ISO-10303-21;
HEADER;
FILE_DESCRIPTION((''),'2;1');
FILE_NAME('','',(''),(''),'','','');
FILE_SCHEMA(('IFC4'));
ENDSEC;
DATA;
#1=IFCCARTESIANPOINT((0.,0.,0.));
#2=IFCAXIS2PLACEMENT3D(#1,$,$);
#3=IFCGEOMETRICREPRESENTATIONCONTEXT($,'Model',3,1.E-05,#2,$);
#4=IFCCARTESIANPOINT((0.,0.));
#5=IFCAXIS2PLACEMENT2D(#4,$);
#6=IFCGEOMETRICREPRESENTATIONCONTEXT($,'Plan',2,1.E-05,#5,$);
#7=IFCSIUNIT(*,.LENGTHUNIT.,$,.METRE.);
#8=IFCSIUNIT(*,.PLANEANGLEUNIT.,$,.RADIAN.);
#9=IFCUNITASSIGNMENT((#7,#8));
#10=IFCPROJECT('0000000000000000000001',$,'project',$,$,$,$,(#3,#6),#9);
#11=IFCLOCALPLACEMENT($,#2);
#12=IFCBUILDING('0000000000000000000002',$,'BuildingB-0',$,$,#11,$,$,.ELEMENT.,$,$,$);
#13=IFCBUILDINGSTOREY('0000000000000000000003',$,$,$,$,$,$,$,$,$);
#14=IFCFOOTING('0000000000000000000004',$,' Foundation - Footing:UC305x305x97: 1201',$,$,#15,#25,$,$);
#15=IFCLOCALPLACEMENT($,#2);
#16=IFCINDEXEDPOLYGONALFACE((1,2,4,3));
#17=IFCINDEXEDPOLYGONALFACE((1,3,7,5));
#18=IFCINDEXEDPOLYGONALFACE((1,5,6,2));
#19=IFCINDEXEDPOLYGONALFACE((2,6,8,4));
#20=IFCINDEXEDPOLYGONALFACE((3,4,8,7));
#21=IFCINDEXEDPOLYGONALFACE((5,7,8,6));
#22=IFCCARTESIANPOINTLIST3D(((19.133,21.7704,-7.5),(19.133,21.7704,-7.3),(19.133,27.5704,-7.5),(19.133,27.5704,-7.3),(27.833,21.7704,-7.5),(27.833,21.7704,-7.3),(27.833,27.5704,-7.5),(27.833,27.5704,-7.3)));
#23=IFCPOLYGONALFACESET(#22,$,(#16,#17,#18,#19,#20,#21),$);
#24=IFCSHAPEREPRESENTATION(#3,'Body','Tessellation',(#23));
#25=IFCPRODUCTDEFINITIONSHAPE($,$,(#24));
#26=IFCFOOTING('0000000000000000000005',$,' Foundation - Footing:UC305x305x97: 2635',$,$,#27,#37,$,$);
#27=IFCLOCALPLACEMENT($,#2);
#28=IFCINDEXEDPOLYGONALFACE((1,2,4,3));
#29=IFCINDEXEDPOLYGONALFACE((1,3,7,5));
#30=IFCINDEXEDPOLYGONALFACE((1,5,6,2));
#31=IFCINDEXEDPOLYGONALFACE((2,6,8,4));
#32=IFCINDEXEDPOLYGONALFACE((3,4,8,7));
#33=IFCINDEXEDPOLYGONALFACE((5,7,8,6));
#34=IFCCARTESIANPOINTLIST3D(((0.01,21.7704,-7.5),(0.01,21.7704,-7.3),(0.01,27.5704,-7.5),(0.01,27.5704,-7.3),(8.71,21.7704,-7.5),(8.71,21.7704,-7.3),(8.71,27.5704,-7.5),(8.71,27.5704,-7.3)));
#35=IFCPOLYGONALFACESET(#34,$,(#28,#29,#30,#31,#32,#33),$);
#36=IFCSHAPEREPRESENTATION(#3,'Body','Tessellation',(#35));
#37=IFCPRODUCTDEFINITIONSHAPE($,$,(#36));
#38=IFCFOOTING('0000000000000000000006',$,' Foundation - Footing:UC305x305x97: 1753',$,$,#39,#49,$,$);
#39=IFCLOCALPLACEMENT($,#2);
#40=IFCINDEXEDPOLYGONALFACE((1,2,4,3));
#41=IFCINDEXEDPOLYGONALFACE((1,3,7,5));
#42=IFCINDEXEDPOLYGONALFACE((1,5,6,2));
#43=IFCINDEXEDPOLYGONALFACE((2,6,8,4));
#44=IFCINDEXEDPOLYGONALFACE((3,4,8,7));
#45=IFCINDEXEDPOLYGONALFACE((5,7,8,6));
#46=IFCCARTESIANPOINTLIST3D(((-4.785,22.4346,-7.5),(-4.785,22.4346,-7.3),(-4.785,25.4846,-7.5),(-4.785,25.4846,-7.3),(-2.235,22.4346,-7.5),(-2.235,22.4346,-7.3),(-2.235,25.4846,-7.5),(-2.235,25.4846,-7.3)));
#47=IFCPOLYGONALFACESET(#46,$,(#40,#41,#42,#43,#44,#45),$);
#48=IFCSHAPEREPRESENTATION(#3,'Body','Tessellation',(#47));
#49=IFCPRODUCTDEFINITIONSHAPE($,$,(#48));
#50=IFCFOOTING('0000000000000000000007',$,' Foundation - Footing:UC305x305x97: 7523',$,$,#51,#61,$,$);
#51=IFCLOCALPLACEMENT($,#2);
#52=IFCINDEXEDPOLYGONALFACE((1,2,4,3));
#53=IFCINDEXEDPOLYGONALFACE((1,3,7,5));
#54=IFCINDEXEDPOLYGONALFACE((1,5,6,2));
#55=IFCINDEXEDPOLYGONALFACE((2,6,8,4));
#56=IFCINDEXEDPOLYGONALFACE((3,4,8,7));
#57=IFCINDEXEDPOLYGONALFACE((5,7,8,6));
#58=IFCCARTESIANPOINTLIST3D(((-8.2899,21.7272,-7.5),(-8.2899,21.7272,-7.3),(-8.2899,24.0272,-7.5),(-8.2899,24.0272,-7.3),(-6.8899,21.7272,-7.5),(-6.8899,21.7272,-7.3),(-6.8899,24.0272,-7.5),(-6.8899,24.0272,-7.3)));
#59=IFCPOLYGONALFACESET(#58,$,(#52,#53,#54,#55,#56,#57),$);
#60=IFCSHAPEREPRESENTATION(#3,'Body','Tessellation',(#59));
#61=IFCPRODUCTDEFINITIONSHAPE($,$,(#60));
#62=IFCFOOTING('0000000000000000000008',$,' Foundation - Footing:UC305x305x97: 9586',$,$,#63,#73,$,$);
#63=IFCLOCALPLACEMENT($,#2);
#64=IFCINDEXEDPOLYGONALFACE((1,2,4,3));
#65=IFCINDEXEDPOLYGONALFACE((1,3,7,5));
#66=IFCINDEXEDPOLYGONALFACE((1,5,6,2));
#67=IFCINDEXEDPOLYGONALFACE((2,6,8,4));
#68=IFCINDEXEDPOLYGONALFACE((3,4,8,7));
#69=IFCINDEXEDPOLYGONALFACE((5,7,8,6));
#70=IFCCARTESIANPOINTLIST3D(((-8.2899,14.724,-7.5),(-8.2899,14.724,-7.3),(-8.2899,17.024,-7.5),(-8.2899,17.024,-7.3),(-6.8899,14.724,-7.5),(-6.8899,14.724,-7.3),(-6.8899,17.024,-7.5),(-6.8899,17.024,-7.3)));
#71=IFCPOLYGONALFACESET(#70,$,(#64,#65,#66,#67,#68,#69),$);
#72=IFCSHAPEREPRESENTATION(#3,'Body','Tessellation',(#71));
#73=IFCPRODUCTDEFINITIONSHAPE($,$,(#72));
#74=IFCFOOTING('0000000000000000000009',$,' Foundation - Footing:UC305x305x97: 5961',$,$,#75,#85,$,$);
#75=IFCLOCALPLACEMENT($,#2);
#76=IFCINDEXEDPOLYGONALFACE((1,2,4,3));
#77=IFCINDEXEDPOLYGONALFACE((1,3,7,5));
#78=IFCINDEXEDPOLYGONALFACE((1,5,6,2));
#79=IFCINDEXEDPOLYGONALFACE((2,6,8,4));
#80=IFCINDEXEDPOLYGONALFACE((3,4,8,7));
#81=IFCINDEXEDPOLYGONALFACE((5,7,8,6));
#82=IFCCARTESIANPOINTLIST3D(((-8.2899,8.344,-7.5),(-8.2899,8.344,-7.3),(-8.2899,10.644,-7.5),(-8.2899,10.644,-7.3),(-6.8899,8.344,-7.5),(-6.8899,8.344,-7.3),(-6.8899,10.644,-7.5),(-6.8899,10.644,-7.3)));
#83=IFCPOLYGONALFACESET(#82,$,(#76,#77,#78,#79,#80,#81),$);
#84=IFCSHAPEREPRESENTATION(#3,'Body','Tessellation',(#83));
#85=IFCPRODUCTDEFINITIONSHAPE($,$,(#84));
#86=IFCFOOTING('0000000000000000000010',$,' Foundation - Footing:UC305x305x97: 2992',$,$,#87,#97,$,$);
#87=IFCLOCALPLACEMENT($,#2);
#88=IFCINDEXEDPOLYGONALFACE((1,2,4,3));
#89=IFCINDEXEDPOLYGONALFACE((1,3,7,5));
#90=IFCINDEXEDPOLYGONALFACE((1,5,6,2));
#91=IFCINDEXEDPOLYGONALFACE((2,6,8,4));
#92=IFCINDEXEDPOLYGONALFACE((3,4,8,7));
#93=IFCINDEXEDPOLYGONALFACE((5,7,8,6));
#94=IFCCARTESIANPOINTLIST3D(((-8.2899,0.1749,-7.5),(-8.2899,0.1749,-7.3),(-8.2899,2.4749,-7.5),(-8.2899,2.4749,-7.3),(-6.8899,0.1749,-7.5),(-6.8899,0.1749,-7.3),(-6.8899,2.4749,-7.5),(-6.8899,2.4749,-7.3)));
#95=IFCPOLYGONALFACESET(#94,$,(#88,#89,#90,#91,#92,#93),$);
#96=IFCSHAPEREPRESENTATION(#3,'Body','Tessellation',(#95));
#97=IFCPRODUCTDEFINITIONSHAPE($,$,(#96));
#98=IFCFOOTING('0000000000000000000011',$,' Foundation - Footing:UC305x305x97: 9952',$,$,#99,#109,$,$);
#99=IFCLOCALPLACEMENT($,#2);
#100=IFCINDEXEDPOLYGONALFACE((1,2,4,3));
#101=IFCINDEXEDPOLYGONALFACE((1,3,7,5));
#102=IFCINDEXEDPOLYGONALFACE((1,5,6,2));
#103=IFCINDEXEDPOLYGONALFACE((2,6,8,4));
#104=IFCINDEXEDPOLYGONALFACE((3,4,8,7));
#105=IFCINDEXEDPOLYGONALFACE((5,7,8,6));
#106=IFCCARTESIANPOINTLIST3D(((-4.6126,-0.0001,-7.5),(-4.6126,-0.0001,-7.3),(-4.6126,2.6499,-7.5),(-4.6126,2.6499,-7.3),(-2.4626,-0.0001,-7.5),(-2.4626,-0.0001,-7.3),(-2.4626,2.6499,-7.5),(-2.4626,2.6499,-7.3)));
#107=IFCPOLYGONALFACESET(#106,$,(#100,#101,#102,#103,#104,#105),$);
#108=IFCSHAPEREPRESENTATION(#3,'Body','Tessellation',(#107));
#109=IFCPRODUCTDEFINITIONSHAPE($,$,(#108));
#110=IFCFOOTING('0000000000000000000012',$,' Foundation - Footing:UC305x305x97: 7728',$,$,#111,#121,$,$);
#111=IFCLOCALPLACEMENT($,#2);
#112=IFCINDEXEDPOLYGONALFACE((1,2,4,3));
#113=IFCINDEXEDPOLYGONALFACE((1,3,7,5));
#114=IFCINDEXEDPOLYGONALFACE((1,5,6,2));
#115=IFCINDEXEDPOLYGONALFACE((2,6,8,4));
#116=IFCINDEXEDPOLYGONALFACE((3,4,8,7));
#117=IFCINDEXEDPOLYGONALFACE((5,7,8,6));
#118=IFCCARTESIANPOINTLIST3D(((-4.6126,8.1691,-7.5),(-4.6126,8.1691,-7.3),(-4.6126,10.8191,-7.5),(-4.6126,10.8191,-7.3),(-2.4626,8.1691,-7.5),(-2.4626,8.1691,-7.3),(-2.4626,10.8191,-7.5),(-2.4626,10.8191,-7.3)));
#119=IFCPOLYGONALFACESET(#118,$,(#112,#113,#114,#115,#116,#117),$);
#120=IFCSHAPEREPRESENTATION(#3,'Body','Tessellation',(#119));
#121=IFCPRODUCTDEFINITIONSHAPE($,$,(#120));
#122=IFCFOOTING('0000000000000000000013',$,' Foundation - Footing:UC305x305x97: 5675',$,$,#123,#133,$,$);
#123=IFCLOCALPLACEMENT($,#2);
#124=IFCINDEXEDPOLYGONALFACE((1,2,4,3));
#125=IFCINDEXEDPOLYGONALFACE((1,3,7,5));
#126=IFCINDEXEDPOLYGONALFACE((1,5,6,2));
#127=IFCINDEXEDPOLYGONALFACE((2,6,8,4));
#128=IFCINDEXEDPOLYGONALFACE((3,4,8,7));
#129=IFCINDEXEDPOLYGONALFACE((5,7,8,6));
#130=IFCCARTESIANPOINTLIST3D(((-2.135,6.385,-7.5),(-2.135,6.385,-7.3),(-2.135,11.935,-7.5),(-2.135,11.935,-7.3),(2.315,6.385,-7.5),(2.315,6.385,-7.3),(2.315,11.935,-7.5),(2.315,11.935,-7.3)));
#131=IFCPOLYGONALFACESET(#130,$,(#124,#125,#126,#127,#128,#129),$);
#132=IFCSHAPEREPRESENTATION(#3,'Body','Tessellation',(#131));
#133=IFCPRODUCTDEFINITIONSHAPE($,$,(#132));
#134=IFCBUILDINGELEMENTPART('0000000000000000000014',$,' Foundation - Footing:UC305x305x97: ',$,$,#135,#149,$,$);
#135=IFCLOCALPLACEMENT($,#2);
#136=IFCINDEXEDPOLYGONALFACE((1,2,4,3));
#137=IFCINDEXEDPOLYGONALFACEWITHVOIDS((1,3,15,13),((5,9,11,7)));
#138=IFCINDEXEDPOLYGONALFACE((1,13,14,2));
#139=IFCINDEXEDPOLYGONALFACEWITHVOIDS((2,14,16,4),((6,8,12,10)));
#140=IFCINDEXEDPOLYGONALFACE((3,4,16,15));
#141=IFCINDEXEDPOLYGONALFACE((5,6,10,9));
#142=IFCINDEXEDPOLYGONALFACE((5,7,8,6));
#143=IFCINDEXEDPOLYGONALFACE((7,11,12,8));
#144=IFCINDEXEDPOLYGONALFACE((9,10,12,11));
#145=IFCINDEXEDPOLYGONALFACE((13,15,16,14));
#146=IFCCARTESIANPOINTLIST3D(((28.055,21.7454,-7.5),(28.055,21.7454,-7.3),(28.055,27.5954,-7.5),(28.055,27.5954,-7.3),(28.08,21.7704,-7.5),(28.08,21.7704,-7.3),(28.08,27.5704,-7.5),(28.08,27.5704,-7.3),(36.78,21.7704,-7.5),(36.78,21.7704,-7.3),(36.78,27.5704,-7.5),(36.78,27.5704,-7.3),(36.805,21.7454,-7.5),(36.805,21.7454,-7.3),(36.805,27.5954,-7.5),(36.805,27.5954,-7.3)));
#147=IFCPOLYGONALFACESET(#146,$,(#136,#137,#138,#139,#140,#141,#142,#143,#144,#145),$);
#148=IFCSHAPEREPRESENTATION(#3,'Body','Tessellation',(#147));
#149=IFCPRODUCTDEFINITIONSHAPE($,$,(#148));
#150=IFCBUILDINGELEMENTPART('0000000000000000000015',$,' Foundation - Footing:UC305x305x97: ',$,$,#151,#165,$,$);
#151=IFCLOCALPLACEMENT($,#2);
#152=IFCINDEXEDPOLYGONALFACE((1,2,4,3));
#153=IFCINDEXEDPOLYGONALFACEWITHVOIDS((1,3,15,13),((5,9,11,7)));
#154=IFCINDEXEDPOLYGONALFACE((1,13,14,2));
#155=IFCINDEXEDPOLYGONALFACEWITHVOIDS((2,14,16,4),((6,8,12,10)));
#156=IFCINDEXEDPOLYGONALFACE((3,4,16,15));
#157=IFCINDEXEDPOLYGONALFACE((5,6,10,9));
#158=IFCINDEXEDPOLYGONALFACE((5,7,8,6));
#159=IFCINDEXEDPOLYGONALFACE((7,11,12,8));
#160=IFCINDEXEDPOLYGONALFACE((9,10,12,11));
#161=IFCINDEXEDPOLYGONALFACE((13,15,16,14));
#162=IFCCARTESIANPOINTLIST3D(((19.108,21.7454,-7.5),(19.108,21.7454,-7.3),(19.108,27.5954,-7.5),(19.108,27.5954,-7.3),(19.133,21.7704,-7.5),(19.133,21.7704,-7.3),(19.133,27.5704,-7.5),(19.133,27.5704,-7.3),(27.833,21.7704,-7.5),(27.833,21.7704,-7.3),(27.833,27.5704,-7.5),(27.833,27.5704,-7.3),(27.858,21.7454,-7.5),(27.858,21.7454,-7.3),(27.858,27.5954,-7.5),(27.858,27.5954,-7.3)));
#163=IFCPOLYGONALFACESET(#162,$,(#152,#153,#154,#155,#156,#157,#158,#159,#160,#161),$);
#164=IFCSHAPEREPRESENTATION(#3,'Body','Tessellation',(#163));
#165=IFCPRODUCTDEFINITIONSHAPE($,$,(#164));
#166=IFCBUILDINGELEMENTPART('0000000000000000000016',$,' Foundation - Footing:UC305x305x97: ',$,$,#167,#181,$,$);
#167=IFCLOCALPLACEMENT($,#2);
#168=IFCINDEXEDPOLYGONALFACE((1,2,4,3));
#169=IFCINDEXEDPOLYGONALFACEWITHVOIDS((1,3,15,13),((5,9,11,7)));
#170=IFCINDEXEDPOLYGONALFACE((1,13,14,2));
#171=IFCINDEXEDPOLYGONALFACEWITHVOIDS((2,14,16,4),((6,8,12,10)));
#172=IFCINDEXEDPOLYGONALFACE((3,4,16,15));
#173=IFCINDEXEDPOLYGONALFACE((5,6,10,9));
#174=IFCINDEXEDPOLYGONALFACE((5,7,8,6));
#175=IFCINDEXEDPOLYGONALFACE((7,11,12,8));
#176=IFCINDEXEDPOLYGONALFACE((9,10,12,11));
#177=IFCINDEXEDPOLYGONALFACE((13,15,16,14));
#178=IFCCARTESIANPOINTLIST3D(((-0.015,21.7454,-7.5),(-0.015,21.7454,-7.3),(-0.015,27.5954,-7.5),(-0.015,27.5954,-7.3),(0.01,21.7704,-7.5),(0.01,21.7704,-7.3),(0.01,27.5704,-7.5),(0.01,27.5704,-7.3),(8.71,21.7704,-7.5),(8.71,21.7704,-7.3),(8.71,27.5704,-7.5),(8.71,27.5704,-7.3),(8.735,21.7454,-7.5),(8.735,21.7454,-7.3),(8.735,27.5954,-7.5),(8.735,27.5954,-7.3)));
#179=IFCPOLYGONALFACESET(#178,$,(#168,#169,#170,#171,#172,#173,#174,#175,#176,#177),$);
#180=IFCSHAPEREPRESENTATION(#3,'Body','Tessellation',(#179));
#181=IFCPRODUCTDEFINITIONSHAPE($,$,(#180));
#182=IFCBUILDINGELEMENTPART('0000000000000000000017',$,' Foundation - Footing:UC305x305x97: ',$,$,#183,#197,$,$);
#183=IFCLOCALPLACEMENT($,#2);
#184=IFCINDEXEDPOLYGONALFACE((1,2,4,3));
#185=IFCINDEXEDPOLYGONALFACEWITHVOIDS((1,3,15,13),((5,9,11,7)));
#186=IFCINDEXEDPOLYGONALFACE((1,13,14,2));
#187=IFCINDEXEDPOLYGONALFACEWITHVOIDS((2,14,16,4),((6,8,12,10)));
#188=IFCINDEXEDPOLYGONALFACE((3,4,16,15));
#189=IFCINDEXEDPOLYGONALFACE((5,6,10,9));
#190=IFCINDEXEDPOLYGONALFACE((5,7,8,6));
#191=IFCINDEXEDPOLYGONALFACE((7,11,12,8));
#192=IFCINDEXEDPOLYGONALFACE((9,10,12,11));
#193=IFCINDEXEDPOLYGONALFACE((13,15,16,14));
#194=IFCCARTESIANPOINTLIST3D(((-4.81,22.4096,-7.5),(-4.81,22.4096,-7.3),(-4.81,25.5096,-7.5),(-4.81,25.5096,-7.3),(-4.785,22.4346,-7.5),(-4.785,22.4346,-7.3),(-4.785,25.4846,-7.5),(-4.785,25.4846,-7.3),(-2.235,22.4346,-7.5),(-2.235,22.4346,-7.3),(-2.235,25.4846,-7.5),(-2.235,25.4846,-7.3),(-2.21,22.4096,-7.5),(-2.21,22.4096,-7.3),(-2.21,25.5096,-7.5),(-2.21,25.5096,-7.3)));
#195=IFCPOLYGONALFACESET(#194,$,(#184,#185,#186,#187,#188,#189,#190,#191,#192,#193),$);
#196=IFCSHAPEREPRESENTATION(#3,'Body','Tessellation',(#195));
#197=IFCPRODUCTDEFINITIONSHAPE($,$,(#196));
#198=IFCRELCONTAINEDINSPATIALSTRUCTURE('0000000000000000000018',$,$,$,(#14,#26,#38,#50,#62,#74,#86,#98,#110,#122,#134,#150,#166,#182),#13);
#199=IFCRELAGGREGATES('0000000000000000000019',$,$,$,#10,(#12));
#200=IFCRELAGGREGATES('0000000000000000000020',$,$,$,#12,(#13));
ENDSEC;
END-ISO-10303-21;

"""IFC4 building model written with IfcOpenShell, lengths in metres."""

from ifc_helpers import new_model, si_unit, origin, origin_2d, place, context, project, spatial, polyline, outline, extrude, element, save


model = new_model("IFC4")

# Units and contexts
model_context = context("Model", 3, precision=1e-05, world=origin())
plan_context = context("Plan", 2, precision=1e-05, world=origin_2d())
ifc_project = project(units=[si_unit("LENGTHUNIT", "METRE"), si_unit("PLANEANGLEUNIT", "RADIAN")], contexts=[model_context, plan_context])

# Building, storey
building_placement = place(None, origin())
building = spatial("IfcBuilding", under=ifc_project, at=building_placement, Name="BuildingB-0", CompositionType="ELEMENT")
storey = spatial("IfcBuildingStorey", under=building)

# Footings
element("IfcFooting", 1, inside=storey, Name=" Foundation - Footing:UC305x305x97: 1201", context=model_context, shape_type="SweptSolid", body=[
    extrude(outline(polyline([(27.833, 27.5704, -7.5), (19.133, 27.5704, -7.5), (19.133, 21.7704, -7.5), (27.833, 21.7704, -7.5), (27.833, 27.5704, -7.5)])), None, (0.0, 0.0, 1.0), 0.2),
])
element("IfcFooting", 2, inside=storey, Name=" Foundation - Footing:UC305x305x97: 2635", context=model_context, shape_type="SweptSolid", body=[
    extrude(outline(polyline([(8.71, 27.5704, -7.5), (0.01, 27.5704, -7.5), (0.01, 21.7704, -7.5), (8.71, 21.7704, -7.5), (8.71, 27.5704, -7.5)])), None, (0.0, 0.0, 1.0), 0.2),
])
element("IfcFooting", 3, inside=storey, Name=" Foundation - Footing:UC305x305x97: 1753", context=model_context, shape_type="SweptSolid", body=[
    extrude(outline(polyline([(-2.235, 25.4846, -7.5), (-4.785, 25.4846, -7.5), (-4.785, 22.4346, -7.5), (-2.235, 22.4346, -7.5), (-2.235, 25.4846, -7.5)])), None, (0.0, 0.0, 1.0), 0.2),
])
element("IfcFooting", 4, inside=storey, Name=" Foundation - Footing:UC305x305x97: 7523", context=model_context, shape_type="SweptSolid", body=[
    extrude(outline(polyline([(-6.8899, 24.0272, -7.5), (-8.2899, 24.0272, -7.5), (-8.2899, 21.7272, -7.5), (-6.8899, 21.7272, -7.5), (-6.8899, 24.0272, -7.5)])), None, (0.0, 0.0, 1.0), 0.2),
])
element("IfcFooting", 5, inside=storey, Name=" Foundation - Footing:UC305x305x97: 9586", context=model_context, shape_type="SweptSolid", body=[
    extrude(outline(polyline([(-8.2899, 14.724, -7.5), (-6.8899, 14.724, -7.5), (-6.8899, 17.024, -7.5), (-8.2899, 17.024, -7.5), (-8.2899, 14.724, -7.5)])), None, (0.0, 0.0, 1.0), 0.2),
])
element("IfcFooting", 6, inside=storey, Name=" Foundation - Footing:UC305x305x97: 5961", context=model_context, shape_type="SweptSolid", body=[
    extrude(outline(polyline([(-8.2899, 8.344, -7.5), (-6.8899, 8.344, -7.5), (-6.8899, 10.644, -7.5), (-8.2899, 10.644, -7.5), (-8.2899, 8.344, -7.5)])), None, (0.0, 0.0, 1.0), 0.2),
])
element("IfcFooting", 7, inside=storey, Name=" Foundation - Footing:UC305x305x97: 2992", context=model_context, shape_type="SweptSolid", body=[
    extrude(outline(polyline([(-8.2899, 0.1749, -7.5), (-6.8899, 0.1749, -7.5), (-6.8899, 2.4749, -7.5), (-8.2899, 2.4749, -7.5), (-8.2899, 0.1749, -7.5)])), None, (0.0, 0.0, 1.0), 0.2),
])
element("IfcFooting", 8, inside=storey, Name=" Foundation - Footing:UC305x305x97: 9952", context=model_context, shape_type="SweptSolid", body=[
    extrude(outline(polyline([(-4.6126, -0.0001, -7.5), (-2.4626, -0.0001, -7.5), (-2.4626, 2.6499, -7.5), (-4.6126, 2.6499, -7.5), (-4.6126, -0.0001, -7.5)])), None, (0.0, 0.0, 1.0), 0.2),
])
element("IfcFooting", 9, inside=storey, Name=" Foundation - Footing:UC305x305x97: 7728", context=model_context, shape_type="SweptSolid", body=[
    extrude(outline(polyline([(-4.6126, 8.1691, -7.5), (-2.4626, 8.1691, -7.5), (-2.4626, 10.8191, -7.5), (-4.6126, 10.8191, -7.5), (-4.6126, 8.1691, -7.5)])), None, (0.0, 0.0, 1.0), 0.2),
])
element("IfcFooting", 10, inside=storey, Name=" Foundation - Footing:UC305x305x97: 5675", context=model_context, shape_type="SweptSolid", body=[
    extrude(outline(polyline([(-2.135, 6.385, -7.5), (2.315, 6.385, -7.5), (2.315, 11.935, -7.5), (-2.135, 11.935, -7.5), (-2.135, 6.385, -7.5)])), None, (0.0, 0.0, 1.0), 0.2),
])

# Building element parts, openings
building_element_part_1 = element("IfcBuildingElementPart", 11, inside=storey, Name=" Foundation - Footing:UC305x305x97: ", context=model_context, shape_type="SweptSolid", body=[
    extrude(outline(polyline([(28.055, 21.7454, -7.5), (36.805, 21.7454, -7.5), (36.805, 27.5954, -7.5), (28.055, 27.5954, -7.5), (28.055, 21.7454, -7.5)])), None, (0.0, 0.0, 1.0), 0.2),
])
element("IfcOpeningElement", 12, inside=storey, cuts=building_element_part_1, context=model_context, shape_type="SweptSolid", body=[
    extrude(outline(polyline([(28.08, 21.7704, -7.5), (36.78, 21.7704, -7.5), (36.78, 27.5704, -7.5), (28.08, 27.5704, -7.5), (28.08, 21.7704, -7.5)])), None, (0.0, 0.0, 1.0), 0.2),
])
building_element_part_2 = element("IfcBuildingElementPart", 13, inside=storey, Name=" Foundation - Footing:UC305x305x97: ", context=model_context, shape_type="SweptSolid", body=[
    extrude(outline(polyline([(27.858, 27.5954, -7.5), (19.108, 27.5954, -7.5), (19.108, 21.7454, -7.5), (27.858, 21.7454, -7.5), (27.858, 27.5954, -7.5)])), None, (0.0, 0.0, 1.0), 0.2),
])
element("IfcOpeningElement", 14, inside=storey, cuts=building_element_part_2, context=model_context, shape_type="SweptSolid", body=[
    extrude(outline(polyline([(27.833, 27.5704, -7.5), (19.133, 27.5704, -7.5), (19.133, 21.7704, -7.5), (27.833, 21.7704, -7.5), (27.833, 27.5704, -7.5)])), None, (0.0, 0.0, 1.0), 0.2),
])
building_element_part_3 = element("IfcBuildingElementPart", 15, inside=storey, Name=" Foundation - Footing:UC305x305x97: ", context=model_context, shape_type="SweptSolid", body=[
    extrude(outline(polyline([(8.735, 27.5954, -7.5), (-0.015, 27.5954, -7.5), (-0.015, 21.7454, -7.5), (8.735, 21.7454, -7.5), (8.735, 27.5954, -7.5)])), None, (0.0, 0.0, 1.0), 0.2),
])
element("IfcOpeningElement", 16, inside=storey, cuts=building_element_part_3, context=model_context, shape_type="SweptSolid", body=[
    extrude(outline(polyline([(8.71, 27.5704, -7.5), (0.01, 27.5704, -7.5), (0.01, 21.7704, -7.5), (8.71, 21.7704, -7.5), (8.71, 27.5704, -7.5)])), None, (0.0, 0.0, 1.0), 0.2),
])
building_element_part_4 = element("IfcBuildingElementPart", 17, inside=storey, Name=" Foundation - Footing:UC305x305x97: ", context=model_context, shape_type="SweptSolid", body=[
    extrude(outline(polyline([(-2.21, 25.5096, -7.5), (-4.81, 25.5096, -7.5), (-4.81, 22.4096, -7.5), (-2.21, 22.4096, -7.5), (-2.21, 25.5096, -7.5)])), None, (0.0, 0.0, 1.0), 0.2),
])
element("IfcOpeningElement", 18, inside=storey, cuts=building_element_part_4, context=model_context, shape_type="SweptSolid", body=[
    extrude(outline(polyline([(-2.235, 25.4846, -7.5), (-4.785, 25.4846, -7.5), (-4.785, 22.4346, -7.5), (-2.235, 22.4346, -7.5), (-2.235, 25.4846, -7.5)])), None, (0.0, 0.0, 1.0), 0.2),
])

save(model, "model.ifc")
